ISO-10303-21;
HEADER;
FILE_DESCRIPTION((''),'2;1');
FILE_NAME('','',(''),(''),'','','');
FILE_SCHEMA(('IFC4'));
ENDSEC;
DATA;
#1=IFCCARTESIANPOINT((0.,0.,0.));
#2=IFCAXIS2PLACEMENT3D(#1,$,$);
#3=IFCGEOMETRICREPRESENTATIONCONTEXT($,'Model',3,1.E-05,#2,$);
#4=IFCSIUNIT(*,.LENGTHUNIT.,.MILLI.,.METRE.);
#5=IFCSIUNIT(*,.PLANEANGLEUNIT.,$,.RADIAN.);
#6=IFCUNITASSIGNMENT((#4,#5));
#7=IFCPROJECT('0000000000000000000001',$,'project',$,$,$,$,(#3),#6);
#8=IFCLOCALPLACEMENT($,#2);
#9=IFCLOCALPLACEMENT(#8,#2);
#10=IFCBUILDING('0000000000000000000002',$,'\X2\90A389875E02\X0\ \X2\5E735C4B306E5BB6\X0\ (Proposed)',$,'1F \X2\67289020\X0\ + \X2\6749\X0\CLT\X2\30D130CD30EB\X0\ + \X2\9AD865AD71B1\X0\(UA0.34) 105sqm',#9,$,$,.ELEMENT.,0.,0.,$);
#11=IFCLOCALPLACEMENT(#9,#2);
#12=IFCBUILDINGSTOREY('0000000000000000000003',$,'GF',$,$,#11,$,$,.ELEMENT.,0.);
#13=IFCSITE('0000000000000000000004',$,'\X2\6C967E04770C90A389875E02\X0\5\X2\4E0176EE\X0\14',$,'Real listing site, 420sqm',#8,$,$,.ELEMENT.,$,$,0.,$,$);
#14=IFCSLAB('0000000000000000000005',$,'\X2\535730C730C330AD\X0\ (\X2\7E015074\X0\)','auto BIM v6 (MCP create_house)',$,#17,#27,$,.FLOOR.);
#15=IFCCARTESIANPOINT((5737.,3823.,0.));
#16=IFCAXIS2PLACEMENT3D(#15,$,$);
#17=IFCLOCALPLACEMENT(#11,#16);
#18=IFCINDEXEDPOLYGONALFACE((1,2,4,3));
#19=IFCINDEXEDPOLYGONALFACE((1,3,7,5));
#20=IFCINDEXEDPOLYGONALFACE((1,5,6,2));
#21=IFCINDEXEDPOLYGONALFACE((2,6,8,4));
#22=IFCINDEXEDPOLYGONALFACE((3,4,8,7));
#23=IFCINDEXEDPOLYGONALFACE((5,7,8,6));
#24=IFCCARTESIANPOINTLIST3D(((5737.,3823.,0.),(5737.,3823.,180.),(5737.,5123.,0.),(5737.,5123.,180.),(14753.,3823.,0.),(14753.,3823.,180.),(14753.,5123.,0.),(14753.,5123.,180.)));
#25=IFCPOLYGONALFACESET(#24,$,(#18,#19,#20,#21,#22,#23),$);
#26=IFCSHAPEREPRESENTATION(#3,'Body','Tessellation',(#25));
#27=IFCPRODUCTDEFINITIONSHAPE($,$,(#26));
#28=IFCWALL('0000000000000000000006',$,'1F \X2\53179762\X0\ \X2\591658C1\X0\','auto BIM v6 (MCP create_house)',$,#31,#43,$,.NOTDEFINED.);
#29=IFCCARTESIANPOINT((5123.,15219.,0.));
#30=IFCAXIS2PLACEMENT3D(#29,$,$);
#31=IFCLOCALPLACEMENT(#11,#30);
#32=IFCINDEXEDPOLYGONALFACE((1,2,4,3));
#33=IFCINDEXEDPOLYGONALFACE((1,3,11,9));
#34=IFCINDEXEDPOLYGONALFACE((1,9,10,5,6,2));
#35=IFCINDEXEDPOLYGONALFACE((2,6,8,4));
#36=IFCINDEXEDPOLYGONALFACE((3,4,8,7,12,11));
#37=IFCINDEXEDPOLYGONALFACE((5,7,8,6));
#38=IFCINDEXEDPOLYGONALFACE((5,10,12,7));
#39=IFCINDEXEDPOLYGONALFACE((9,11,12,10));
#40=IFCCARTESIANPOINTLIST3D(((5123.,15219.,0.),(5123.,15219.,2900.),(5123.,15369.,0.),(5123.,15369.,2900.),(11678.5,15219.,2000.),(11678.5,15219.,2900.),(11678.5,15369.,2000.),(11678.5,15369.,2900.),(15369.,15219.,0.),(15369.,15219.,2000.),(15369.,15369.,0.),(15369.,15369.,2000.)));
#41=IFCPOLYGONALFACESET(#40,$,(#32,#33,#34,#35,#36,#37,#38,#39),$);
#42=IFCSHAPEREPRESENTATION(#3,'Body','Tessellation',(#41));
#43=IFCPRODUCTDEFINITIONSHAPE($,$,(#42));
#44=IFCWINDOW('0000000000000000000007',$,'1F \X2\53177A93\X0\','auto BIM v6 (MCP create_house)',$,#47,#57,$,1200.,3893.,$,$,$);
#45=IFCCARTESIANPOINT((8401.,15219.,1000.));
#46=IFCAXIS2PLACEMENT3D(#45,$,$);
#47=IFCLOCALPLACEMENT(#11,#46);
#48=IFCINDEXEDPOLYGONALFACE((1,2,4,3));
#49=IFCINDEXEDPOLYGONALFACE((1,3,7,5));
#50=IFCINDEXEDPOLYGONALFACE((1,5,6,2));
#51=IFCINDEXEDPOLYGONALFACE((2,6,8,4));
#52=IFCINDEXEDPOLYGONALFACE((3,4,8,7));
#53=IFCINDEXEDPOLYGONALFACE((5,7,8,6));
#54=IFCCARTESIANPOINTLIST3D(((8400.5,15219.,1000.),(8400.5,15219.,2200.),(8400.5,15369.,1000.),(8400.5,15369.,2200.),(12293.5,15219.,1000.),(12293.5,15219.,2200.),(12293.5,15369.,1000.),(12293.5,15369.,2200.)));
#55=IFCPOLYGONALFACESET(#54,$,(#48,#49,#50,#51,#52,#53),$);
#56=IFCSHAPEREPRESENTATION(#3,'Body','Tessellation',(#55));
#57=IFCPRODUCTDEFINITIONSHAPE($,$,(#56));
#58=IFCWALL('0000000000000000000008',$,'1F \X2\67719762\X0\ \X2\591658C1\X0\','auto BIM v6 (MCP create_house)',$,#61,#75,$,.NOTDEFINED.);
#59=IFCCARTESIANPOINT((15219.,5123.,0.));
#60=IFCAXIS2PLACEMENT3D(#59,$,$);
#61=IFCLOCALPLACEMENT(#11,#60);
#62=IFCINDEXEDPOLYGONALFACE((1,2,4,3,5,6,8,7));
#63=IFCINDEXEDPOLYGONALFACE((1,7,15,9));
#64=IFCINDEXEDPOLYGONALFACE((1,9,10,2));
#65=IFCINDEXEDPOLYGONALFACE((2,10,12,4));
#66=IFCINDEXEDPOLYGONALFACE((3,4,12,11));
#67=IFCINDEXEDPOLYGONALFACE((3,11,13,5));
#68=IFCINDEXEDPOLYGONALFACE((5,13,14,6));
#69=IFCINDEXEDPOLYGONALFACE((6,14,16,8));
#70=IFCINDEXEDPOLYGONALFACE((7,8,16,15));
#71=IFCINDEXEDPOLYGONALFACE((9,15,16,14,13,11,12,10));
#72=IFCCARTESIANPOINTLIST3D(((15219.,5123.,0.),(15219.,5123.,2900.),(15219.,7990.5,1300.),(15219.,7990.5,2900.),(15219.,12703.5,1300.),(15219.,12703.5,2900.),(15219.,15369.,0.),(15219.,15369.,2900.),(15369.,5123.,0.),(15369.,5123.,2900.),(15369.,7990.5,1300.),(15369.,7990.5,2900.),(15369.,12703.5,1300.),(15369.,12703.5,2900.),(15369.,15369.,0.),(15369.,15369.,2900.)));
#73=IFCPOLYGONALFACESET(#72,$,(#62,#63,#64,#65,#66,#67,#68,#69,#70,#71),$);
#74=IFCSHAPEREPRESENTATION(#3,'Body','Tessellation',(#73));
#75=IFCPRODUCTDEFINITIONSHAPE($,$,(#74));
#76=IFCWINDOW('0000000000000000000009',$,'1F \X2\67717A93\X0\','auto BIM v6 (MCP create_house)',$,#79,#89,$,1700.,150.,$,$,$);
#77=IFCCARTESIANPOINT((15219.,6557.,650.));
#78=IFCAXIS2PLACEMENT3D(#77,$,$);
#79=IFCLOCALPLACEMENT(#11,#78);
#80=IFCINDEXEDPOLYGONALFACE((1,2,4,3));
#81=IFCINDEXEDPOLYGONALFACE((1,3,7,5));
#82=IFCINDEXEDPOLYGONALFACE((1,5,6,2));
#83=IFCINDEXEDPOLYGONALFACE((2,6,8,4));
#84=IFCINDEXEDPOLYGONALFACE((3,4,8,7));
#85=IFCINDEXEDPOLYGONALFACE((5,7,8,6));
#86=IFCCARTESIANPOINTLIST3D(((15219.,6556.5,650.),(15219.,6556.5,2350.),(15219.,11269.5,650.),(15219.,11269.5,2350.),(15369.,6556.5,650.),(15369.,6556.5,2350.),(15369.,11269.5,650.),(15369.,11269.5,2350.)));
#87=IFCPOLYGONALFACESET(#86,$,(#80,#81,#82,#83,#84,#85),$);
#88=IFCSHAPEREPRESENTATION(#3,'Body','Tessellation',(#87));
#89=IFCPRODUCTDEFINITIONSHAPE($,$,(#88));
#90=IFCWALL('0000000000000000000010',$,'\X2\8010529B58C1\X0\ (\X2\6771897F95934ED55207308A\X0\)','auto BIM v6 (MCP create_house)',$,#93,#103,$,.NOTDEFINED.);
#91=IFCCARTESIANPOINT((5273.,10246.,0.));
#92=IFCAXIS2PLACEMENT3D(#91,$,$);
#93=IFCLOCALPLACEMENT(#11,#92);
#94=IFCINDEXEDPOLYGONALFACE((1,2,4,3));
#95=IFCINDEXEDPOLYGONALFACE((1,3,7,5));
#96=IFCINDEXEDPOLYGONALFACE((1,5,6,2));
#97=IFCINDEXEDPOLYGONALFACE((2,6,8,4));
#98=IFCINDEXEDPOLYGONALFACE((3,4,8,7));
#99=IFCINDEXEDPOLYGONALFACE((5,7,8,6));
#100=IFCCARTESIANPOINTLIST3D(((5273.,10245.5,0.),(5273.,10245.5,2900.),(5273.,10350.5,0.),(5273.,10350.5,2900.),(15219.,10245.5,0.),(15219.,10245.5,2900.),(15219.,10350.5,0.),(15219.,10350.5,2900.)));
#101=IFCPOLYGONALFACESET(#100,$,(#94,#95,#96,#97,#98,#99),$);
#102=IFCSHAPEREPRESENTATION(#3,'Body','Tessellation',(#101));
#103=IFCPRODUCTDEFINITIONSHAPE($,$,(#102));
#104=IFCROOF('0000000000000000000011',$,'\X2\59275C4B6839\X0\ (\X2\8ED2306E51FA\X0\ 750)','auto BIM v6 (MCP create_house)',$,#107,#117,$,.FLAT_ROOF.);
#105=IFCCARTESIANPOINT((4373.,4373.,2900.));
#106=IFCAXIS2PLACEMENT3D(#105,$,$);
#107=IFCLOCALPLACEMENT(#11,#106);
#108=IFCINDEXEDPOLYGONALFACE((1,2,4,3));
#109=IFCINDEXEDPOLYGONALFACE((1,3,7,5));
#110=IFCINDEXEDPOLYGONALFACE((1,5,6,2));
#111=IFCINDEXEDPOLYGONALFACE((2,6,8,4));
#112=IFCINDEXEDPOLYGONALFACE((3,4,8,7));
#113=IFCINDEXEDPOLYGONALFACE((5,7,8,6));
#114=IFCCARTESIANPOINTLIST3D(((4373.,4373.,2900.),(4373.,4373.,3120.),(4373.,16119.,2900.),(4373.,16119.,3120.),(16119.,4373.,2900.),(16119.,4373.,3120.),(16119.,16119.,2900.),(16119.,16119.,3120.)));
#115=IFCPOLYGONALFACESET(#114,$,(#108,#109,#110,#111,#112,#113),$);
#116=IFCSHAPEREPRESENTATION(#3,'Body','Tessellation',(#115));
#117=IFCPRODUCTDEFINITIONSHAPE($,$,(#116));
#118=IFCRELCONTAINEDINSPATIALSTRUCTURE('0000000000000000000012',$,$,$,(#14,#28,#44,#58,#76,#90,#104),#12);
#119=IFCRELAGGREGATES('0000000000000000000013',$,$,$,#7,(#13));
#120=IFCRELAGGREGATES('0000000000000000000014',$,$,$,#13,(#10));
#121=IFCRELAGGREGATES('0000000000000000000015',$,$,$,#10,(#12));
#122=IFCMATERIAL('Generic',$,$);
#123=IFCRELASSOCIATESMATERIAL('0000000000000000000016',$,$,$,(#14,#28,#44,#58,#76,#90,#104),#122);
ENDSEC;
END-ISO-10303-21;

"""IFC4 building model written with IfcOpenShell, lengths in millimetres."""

from ifc_helpers import new_model, si_unit, frame, frame_2d, origin, place, context, project, spatial, rectangle, extrude, material, element, fill, save


model = new_model("IFC4")

# Units and contexts
model_context = context("Model", 3, precision=1e-05, world=origin())
ifc_project = project(units=[si_unit("LENGTHUNIT", "METRE", prefix="MILLI"), si_unit("PLANEANGLEUNIT", "RADIAN")], contexts=[model_context])

# Site, building, storey
site_placement = place(None, origin())
site = spatial("IfcSite", under=ifc_project, at=site_placement, Name="沖縄県那覇市5丁目14", ObjectType="Real listing site, 420sqm", CompositionType="ELEMENT", RefElevation=0.0)
building_placement = place(site_placement, origin())
building = spatial("IfcBuilding", under=site, at=building_placement, Name="那覇市 平屋の家 (Proposed)", ObjectType="1F 木造 + 杉CLTパネル + 高断熱(UA0.34) 105sqm", CompositionType="ELEMENT", ElevationOfRefHeight=0.0, ElevationOfTerrain=0.0)
storey_placement = place(building_placement, origin())
storey = spatial("IfcBuildingStorey", under=building, at=storey_placement, Name="GF", CompositionType="ELEMENT", Elevation=0.0)

# Slab
ifc_material = material(Name="Generic")
slab_1_placement = place(storey_placement, frame((5737.0, 3823.0, 0.0)))
element("IfcSlab", 1, at=slab_1_placement, inside=storey, material=ifc_material, Name="南デッキ (縁側)", Description="auto BIM v6 (MCP create_house)", PredefinedType="FLOOR", context=model_context, shape_type="SweptSolid", body=[
    extrude(rectangle(XDim=9016.0, YDim=1300.0, at=frame_2d((4508.0, 650.0))), frame((5737.0, 3823.0, 0.0)), (0.0, 0.0, 1.0), 180.0),
])

# Walls, openings, windows
wall_1_placement = place(storey_placement, frame((5123.0, 15219.0, 0.0)))
wall_1 = element("IfcWall", 2, at=wall_1_placement, inside=storey, material=ifc_material, Name="1F 北面 外壁", Description="auto BIM v6 (MCP create_house)", PredefinedType="NOTDEFINED", context=model_context, shape_type="SweptSolid", body=[
    extrude(rectangle(XDim=10246.0, YDim=150.0, at=frame_2d((5123.0, 75.0))), frame((5123.0, 15219.0, 0.0)), (0.0, 0.0, 1.0), 2900.0),
])
opening_1_placement = place(storey_placement, frame((8401.0, 15219.0, 1000.0)))
opening_1 = element("IfcOpeningElement", 3, at=opening_1_placement, cuts=wall_1, PredefinedType="NOTDEFINED", context=model_context, shape_type="SweptSolid", body=[
    extrude(rectangle(XDim=3893.0, YDim=150.0, at=frame_2d((1946.0, 75.0))), frame((8401.0, 15219.0, 1000.0)), (0.0, 0.0, 1.0), 1200.0),
])
window_1_placement = place(storey_placement, frame((8401.0, 15219.0, 1000.0)))
window_1 = element("IfcWindow", 4, at=window_1_placement, inside=storey, material=ifc_material, Name="1F 北窓", Description="auto BIM v6 (MCP create_house)", OverallHeight=1200.0, OverallWidth=3893.0, context=model_context, shape_type="SweptSolid", body=[
    extrude(rectangle(XDim=3893.0, YDim=150.0, at=frame_2d((1946.0, 75.0))), frame((8401.0, 15219.0, 1000.0)), (0.0, 0.0, 1.0), 1200.0),
])
fill(opening_1, window_1)
wall_2_placement = place(storey_placement, frame((15219.0, 5123.0, 0.0)))
wall_2 = element("IfcWall", 5, at=wall_2_placement, inside=storey, material=ifc_material, Name="1F 東面 外壁", Description="auto BIM v6 (MCP create_house)", PredefinedType="NOTDEFINED", context=model_context, shape_type="SweptSolid", body=[
    extrude(rectangle(XDim=150.0, YDim=10246.0, at=frame_2d((75.0, 5123.0))), frame((15219.0, 5123.0, 0.0)), (0.0, 0.0, 1.0), 2900.0),
])
opening_2_placement = place(storey_placement, frame((15219.0, 6557.0, 650.0)))
opening_2 = element("IfcOpeningElement", 6, at=opening_2_placement, cuts=wall_2, PredefinedType="NOTDEFINED", context=model_context, shape_type="SweptSolid", body=[
    extrude(rectangle(XDim=150.0, YDim=4713.0, at=frame_2d((75.0, 2356.0))), frame((15219.0, 6557.0, 650.0)), (0.0, 0.0, 1.0), 1700.0),
])
window_2_placement = place(storey_placement, frame((15219.0, 6557.0, 650.0)))
window_2 = element("IfcWindow", 7, at=window_2_placement, inside=storey, material=ifc_material, Name="1F 東窓", Description="auto BIM v6 (MCP create_house)", OverallHeight=1700.0, OverallWidth=150.0, context=model_context, shape_type="SweptSolid", body=[
    extrude(rectangle(XDim=150.0, YDim=4713.0, at=frame_2d((75.0, 2356.0))), frame((15219.0, 6557.0, 650.0)), (0.0, 0.0, 1.0), 1700.0),
])
fill(opening_2, window_2)

# Wall
wall_3_placement = place(storey_placement, frame((5273.0, 10246.0, 0.0)))
element("IfcWall", 8, at=wall_3_placement, inside=storey, material=ifc_material, Name="耐力壁 (東西間仕切り)", Description="auto BIM v6 (MCP create_house)", PredefinedType="NOTDEFINED", context=model_context, shape_type="SweptSolid", body=[
    extrude(rectangle(XDim=9946.0, YDim=105.0, at=frame_2d((4973.0, 52.0))), frame((5273.0, 10246.0, 0.0)), (0.0, 0.0, 1.0), 2900.0),
])

# Roof
roof_placement = place(storey_placement, frame((4373.0, 4373.0, 2900.0)))
element("IfcRoof", 9, at=roof_placement, inside=storey, material=ifc_material, Name="大屋根 (軒の出 750)", Description="auto BIM v6 (MCP create_house)", PredefinedType="FLAT_ROOF", context=model_context, shape_type="SweptSolid", body=[
    extrude(rectangle(XDim=11746.0, YDim=11746.0, at=frame_2d((5873.0, 5873.0))), frame((4373.0, 4373.0, 2900.0)), (0.0, 0.0, 1.0), 220.0),
])

save(model, "model.ifc")
